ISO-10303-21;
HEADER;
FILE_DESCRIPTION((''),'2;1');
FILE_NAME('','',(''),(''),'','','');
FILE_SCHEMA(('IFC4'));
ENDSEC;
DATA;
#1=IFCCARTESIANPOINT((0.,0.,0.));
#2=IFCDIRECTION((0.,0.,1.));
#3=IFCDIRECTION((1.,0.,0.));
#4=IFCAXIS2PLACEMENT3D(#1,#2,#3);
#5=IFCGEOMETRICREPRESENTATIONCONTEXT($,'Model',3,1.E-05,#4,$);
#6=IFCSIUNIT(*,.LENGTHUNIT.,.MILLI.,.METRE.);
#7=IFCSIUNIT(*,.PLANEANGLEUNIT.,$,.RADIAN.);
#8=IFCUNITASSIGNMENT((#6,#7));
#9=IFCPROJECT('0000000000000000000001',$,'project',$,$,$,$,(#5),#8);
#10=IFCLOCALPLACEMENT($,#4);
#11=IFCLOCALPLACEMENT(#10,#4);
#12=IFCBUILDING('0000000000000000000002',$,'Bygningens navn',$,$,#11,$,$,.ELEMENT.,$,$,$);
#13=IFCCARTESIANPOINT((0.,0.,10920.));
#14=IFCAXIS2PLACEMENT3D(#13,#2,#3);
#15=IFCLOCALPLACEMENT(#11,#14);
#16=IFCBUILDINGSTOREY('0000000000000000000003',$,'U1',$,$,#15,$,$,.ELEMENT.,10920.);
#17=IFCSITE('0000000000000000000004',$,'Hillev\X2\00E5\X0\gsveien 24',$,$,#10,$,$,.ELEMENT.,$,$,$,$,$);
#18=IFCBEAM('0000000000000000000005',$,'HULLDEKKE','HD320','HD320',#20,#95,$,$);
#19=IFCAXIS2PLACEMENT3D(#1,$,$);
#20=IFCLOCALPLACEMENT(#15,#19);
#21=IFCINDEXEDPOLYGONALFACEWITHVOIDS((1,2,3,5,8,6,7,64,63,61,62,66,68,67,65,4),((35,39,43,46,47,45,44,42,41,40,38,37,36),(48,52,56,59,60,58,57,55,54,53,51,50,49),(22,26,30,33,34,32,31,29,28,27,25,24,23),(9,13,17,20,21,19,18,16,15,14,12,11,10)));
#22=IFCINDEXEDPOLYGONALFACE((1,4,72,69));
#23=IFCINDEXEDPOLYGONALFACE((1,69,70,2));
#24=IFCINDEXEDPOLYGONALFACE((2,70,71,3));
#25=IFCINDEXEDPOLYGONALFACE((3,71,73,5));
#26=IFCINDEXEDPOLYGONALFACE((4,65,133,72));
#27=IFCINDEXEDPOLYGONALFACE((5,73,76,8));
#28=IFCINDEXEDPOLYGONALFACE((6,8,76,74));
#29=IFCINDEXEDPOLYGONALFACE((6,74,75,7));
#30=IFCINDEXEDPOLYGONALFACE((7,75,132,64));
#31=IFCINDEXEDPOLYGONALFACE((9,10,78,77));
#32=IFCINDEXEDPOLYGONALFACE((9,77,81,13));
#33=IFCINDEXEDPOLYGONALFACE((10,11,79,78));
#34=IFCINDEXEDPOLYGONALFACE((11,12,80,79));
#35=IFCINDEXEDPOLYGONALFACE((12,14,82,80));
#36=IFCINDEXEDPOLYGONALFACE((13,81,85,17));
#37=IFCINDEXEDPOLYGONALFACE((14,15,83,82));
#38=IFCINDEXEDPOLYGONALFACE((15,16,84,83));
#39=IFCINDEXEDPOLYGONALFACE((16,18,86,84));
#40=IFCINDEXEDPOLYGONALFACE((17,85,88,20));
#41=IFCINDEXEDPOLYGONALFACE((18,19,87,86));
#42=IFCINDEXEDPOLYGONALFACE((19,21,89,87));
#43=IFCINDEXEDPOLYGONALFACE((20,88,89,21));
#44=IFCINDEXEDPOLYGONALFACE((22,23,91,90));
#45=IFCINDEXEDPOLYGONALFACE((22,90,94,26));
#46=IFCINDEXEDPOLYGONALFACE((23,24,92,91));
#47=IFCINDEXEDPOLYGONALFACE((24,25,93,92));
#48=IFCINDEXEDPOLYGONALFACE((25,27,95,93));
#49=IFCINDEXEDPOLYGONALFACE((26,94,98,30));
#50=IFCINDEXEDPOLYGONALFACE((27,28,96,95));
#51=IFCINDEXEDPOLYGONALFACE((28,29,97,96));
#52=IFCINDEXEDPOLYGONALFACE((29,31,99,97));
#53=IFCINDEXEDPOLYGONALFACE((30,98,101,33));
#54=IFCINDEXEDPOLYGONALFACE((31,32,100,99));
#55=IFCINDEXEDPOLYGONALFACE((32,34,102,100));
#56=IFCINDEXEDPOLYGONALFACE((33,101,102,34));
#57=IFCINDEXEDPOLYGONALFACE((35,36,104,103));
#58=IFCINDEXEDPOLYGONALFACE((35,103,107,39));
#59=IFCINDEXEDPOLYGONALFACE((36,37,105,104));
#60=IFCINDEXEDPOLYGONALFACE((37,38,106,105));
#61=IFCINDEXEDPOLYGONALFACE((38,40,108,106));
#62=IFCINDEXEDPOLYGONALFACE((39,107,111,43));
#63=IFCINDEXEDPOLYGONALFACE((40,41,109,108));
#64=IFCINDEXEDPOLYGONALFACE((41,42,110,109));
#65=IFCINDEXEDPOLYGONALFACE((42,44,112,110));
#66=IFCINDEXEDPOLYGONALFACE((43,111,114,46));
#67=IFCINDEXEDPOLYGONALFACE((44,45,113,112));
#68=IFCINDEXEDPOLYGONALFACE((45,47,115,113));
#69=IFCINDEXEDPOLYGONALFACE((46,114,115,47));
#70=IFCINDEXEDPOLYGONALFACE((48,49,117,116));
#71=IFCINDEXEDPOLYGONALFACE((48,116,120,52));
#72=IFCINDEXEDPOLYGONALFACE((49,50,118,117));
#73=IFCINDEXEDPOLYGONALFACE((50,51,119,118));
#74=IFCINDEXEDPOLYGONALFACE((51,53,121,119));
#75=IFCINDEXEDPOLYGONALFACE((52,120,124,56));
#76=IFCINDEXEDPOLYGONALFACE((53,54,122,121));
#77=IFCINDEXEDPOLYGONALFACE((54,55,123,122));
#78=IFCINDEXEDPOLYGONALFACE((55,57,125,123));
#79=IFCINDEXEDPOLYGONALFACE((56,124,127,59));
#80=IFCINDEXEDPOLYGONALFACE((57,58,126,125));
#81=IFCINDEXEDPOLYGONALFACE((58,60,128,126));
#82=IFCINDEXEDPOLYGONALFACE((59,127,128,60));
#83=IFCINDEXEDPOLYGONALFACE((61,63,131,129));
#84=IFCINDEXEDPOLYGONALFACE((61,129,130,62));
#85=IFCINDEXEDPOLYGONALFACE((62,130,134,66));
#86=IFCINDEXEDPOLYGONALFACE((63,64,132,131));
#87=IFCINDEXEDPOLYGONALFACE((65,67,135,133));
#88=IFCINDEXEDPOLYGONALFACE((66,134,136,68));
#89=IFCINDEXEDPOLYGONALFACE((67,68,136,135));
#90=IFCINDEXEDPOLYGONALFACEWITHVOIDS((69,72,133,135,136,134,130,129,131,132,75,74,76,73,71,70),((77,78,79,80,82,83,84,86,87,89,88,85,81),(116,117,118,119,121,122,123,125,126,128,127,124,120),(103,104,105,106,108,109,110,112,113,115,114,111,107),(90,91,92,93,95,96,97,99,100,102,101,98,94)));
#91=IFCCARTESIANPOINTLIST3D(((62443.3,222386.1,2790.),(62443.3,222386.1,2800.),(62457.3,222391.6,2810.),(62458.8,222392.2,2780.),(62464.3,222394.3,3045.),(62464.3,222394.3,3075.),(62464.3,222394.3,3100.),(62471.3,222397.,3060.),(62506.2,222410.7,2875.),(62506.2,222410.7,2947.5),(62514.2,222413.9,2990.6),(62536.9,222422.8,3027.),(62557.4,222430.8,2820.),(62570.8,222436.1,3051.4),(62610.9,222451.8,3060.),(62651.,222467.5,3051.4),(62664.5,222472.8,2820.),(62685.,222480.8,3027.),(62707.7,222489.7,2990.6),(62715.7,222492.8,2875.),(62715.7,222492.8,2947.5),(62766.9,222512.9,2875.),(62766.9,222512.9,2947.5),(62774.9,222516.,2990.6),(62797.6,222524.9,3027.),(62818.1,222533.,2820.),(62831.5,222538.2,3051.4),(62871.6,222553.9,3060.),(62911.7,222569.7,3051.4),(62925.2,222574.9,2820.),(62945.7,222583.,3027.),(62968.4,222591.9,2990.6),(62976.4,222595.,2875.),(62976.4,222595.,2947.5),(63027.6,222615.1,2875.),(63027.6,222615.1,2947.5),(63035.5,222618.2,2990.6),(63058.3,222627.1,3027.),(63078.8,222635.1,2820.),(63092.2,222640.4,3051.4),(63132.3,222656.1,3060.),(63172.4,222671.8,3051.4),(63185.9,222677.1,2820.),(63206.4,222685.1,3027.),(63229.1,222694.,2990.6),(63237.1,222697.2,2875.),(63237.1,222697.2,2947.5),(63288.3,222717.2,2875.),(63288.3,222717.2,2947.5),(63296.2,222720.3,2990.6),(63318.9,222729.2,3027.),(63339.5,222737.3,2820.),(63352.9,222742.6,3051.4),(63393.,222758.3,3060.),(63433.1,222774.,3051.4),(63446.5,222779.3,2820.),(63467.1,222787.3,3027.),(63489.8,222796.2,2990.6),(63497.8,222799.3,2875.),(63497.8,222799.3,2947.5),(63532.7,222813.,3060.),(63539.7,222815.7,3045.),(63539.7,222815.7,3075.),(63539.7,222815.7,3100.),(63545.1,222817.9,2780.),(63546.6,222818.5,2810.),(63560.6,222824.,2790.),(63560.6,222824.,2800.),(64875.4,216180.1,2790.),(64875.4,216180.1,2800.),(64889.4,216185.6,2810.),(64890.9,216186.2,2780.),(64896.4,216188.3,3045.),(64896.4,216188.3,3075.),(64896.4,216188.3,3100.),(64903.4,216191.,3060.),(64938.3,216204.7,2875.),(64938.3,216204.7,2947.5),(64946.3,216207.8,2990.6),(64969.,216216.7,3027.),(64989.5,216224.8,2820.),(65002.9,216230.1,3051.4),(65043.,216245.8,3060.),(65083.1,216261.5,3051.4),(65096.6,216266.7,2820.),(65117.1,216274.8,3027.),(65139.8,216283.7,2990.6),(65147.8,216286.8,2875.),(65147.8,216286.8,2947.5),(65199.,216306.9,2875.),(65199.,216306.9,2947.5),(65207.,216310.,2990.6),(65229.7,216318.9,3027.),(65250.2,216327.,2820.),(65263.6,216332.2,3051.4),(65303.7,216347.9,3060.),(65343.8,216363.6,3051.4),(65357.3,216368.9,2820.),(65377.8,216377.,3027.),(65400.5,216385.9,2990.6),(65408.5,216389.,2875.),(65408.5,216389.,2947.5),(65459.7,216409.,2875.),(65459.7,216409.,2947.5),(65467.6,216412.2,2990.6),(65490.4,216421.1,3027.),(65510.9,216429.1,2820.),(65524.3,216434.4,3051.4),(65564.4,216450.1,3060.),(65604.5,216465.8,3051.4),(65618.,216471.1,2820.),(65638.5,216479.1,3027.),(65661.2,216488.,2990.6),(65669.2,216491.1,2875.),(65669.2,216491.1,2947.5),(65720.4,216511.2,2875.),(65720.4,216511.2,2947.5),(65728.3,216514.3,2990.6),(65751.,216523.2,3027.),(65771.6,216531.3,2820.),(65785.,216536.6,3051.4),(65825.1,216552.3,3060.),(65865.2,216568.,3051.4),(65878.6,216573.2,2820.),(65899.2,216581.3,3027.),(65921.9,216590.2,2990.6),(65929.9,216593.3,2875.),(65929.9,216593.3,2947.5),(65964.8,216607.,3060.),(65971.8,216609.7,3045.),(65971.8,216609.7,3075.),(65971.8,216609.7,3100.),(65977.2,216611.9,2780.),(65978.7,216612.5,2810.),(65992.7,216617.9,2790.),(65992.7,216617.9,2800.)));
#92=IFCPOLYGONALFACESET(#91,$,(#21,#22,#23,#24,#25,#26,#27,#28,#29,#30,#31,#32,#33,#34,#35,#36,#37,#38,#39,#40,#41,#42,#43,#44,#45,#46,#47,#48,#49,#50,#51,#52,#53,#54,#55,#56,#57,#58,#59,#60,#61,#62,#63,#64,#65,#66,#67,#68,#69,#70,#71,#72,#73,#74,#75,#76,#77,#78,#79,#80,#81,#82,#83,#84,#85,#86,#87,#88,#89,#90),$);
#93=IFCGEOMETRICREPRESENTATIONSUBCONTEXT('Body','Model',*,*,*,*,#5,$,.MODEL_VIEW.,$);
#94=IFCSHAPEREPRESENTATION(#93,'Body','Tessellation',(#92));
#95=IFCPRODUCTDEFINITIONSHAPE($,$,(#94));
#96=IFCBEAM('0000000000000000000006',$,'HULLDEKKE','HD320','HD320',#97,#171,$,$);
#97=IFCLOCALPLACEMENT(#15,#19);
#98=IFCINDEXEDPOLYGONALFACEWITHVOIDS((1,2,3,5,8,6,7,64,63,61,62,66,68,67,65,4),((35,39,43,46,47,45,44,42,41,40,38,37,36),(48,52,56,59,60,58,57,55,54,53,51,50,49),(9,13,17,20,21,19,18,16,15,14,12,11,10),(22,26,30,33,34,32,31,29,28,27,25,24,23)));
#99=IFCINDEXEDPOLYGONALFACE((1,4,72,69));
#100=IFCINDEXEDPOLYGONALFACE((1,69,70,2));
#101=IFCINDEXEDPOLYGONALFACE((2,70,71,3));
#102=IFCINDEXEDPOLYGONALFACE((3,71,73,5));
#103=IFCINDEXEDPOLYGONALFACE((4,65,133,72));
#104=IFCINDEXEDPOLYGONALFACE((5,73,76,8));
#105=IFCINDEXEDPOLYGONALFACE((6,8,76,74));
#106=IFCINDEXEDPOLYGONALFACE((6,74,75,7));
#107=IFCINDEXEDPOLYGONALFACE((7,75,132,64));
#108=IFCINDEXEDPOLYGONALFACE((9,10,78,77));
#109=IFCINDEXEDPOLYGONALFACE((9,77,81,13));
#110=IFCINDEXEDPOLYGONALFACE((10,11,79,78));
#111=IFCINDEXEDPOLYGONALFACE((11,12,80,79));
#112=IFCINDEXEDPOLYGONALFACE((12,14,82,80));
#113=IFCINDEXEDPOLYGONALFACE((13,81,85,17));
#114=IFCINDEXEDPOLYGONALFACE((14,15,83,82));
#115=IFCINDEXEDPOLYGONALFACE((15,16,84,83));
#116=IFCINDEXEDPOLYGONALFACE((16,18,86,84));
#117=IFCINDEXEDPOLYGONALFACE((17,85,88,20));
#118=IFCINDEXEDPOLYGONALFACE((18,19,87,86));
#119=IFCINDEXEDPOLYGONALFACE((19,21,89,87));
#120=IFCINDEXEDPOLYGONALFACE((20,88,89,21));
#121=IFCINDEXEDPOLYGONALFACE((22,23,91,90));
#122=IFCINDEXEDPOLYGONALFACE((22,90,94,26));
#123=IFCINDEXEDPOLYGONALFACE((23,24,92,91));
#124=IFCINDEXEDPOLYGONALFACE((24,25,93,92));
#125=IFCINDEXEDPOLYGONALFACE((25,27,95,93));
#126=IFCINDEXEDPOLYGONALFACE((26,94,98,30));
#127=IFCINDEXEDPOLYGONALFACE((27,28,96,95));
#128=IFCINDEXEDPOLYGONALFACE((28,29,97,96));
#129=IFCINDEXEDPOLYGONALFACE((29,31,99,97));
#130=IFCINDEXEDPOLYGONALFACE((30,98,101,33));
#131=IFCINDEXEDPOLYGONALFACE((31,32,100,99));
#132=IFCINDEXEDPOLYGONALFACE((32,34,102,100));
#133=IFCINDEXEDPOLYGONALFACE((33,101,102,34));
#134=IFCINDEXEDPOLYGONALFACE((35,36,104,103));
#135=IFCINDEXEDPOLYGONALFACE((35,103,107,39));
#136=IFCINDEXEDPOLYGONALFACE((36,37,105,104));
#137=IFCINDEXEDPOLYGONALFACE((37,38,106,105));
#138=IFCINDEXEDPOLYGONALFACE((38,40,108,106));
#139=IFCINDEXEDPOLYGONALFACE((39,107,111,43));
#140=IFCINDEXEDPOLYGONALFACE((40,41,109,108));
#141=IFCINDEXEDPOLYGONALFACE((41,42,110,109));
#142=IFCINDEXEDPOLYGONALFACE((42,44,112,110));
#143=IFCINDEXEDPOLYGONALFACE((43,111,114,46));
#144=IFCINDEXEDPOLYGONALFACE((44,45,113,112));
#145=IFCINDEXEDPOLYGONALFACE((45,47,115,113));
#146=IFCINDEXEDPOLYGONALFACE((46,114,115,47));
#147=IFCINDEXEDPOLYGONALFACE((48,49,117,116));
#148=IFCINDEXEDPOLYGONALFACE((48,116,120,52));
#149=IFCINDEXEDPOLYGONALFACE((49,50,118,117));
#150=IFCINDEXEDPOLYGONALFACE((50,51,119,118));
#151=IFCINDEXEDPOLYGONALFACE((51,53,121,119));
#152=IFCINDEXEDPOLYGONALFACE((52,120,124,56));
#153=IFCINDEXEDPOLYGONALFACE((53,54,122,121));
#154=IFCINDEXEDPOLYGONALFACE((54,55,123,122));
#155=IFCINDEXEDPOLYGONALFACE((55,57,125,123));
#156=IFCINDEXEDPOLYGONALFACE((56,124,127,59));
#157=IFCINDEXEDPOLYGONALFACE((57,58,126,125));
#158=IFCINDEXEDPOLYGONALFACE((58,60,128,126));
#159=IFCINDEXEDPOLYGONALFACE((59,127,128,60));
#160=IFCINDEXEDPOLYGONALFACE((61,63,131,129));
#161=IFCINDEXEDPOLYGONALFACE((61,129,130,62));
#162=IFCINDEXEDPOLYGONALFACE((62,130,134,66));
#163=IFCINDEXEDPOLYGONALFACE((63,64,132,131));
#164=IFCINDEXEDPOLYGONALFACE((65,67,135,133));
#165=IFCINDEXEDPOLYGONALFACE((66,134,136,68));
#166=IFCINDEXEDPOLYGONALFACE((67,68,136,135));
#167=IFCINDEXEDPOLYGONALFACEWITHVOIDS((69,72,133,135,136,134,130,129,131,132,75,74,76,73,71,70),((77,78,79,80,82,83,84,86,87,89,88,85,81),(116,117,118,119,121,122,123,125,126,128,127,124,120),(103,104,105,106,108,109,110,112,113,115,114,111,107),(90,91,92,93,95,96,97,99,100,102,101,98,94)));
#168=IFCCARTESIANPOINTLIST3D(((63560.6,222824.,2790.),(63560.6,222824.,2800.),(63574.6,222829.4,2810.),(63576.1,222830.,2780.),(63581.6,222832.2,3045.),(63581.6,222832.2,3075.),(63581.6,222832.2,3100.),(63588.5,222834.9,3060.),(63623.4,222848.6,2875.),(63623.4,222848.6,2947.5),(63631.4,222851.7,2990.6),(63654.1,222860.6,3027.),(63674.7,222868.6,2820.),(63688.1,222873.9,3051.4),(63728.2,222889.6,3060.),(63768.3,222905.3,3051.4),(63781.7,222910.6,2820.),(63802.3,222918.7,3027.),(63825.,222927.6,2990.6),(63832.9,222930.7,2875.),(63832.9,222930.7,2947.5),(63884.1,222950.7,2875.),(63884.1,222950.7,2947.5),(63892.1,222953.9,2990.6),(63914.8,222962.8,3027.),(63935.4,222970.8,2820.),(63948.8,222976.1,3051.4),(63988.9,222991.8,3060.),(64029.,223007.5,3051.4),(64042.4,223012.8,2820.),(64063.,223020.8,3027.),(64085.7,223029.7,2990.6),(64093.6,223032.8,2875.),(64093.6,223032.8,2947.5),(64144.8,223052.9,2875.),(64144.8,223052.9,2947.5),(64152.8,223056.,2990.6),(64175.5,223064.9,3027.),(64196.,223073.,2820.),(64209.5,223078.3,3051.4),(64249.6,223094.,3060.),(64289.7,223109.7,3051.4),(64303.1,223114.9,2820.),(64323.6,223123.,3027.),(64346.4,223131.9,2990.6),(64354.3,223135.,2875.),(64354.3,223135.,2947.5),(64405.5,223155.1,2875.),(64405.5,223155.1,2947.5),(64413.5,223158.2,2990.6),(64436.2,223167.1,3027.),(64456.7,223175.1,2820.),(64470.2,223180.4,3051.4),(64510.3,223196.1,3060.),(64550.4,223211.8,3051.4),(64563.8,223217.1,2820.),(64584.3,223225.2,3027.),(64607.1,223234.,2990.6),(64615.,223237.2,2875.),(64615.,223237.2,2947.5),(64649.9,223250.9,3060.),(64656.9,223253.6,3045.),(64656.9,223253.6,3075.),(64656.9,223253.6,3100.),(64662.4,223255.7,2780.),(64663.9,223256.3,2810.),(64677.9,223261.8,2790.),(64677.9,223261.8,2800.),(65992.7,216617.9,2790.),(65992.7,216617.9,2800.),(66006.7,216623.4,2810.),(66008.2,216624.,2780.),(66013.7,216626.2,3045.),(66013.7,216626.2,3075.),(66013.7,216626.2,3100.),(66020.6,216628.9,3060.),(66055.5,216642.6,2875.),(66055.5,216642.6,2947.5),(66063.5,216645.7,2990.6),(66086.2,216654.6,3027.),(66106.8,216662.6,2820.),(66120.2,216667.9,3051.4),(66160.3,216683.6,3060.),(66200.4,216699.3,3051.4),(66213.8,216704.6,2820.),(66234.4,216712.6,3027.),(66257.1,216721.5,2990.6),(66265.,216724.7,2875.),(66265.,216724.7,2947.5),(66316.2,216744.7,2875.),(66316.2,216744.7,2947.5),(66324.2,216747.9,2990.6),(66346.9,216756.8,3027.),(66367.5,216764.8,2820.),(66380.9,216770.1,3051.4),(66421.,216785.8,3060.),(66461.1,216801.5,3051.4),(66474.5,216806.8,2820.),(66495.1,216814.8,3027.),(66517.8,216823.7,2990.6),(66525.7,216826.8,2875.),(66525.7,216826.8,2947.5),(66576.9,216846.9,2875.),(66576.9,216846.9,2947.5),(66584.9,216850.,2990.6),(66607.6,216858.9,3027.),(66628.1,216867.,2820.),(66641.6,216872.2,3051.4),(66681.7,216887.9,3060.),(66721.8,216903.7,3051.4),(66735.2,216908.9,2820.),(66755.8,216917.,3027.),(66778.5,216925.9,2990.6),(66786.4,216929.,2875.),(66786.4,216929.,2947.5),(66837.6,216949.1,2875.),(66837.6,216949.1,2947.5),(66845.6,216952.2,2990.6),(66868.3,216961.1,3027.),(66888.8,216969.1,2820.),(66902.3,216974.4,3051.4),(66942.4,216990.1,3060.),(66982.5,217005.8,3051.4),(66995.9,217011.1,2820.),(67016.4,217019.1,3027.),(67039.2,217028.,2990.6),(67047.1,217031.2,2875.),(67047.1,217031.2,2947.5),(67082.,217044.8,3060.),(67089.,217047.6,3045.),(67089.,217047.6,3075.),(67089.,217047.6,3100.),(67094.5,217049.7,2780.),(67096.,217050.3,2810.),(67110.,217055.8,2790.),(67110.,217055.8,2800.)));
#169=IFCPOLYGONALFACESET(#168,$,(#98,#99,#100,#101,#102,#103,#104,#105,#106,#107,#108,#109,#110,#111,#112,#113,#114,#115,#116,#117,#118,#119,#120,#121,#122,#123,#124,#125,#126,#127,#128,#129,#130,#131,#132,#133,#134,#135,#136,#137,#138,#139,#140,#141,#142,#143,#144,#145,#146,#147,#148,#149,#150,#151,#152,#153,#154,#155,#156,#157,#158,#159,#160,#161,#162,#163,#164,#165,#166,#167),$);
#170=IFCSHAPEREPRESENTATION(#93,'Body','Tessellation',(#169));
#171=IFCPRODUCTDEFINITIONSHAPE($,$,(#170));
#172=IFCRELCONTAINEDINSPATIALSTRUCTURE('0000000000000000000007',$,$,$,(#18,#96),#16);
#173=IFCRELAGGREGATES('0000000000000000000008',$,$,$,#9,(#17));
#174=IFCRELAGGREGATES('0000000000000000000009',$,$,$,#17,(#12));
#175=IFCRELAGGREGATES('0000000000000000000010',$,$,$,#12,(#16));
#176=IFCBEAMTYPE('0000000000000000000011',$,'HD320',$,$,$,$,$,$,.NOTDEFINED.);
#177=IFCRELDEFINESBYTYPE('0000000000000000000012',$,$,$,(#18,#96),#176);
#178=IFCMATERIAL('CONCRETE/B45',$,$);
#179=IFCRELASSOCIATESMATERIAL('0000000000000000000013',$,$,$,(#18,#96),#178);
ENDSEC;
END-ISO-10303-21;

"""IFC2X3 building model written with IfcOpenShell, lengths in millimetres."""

from ifc_helpers import new_model, si_unit, frame, origin_with_axes, place, context, subcontext, project, spatial, polyline, outline, extrude, material, type_object, element, save


model = new_model("IFC2X3")

# Units and contexts
model_context = context("Model", 3, precision=1e-05, world=origin_with_axes())
body_context = subcontext(model_context, "Body", "Model", "MODEL_VIEW")
ifc_project = project(units=[si_unit("LENGTHUNIT", "METRE", prefix="MILLI"), si_unit("PLANEANGLEUNIT", "RADIAN")], contexts=[model_context])

# Site, building, storey
site_placement = place(None, origin_with_axes())
site = spatial("IfcSite", under=ifc_project, at=site_placement, Name="Hillevågsveien 24", CompositionType="ELEMENT")
building_placement = place(site_placement, origin_with_axes())
building = spatial("IfcBuilding", under=site, at=building_placement, Name="Bygningens navn", CompositionType="ELEMENT")
storey_placement = place(building_placement, frame((0.0, 0.0, 10920.0), z_axis=(0.0, 0.0, 1.0), x_axis=(1.0, 0.0, 0.0)))
storey = spatial("IfcBuildingStorey", under=building, at=storey_placement, Name="U1", CompositionType="ELEMENT", Elevation=10920.0)

# Beams
ifc_material_1 = material(Name="CONCRETE/B45")
beam_type_1 = type_object("IfcBeamType", Name="HD320", PredefinedType="NOTDEFINED")
beam_1_placement = place(storey_placement, frame((65434.1, 216399.0, 2940.0), z_axis=(0.0, 0.0, 1.0), x_axis=(-0.364876, 0.931056, 0.0)))
element("IfcBeam", 1, at=beam_1_placement, inside=storey, type_object=beam_type_1, material=ifc_material_1, Name="HULLDEKKE", Description="HD320", ObjectType="HD320", context=body_context, shape_type="SweptSolid", body=[
    extrude(outline(polyline([(577.5, 105.0), (585.0, -130.0), (600.0, -140.0), (600.0, -150.0), (583.4, -160.0), (-583.4, -160.0), (-600.0, -150.0), (-600.0, -140.0), (-585.0, -130.0), (-577.5, 105.0), (-570.0, 120.0), (-577.5, 135.0), (-577.5, 160.0), (577.5, 160.0), (577.5, 135.0), (570.0, 120.0), (577.5, 105.0)]), holes=[polyline([(477.5, -120.0), (532.5, -65.0), (532.5, 7.5), (523.9, 50.6), (499.5, 87.0), (463.1, 111.4), (420.0, 120.0), (376.9, 111.4), (340.5, 87.0), (316.1, 50.6), (307.5, 7.5), (307.5, -65.0), (362.5, -120.0), (477.5, -120.0)]), polyline([(197.5, -120.0), (252.5, -65.0), (252.5, 7.5), (243.9, 50.6), (219.5, 87.0), (183.1, 111.4), (140.0, 120.0), (96.9, 111.4), (60.5, 87.0), (36.1, 50.6), (27.5, 7.5), (27.5, -65.0), (82.5, -120.0), (197.5, -120.0)]), polyline([(-82.5, -120.0), (-27.5, -65.0), (-27.5, 7.5), (-36.1, 50.6), (-60.5, 87.0), (-96.9, 111.4), (-140.0, 120.0), (-183.1, 111.4), (-219.5, 87.0), (-243.9, 50.6), (-252.5, 7.5), (-252.5, -65.0), (-197.5, -120.0), (-82.5, -120.0)]), polyline([(-362.5, -120.0), (-307.5, -65.0), (-307.5, 7.5), (-316.1, 50.6), (-340.5, 87.0), (-376.9, 111.4), (-420.0, 120.0), (-463.1, 111.4), (-499.5, 87.0), (-523.9, 50.6), (-532.5, 7.5), (-532.5, -65.0), (-477.5, -120.0), (-362.5, -120.0)])]), frame((6665.6, 0.0, 0.0), z_axis=(-1.0, 0.0, 0.0), x_axis=(0.0, -1.0, 0.0)), (0.0, 0.0, 1.0), 6665.6),
])
beam_2_placement = place(storey_placement, frame((66551.3, 216836.9, 2940.0), z_axis=(0.0, 0.0, 1.0), x_axis=(-0.364876, 0.931056, 0.0)))
element("IfcBeam", 2, at=beam_2_placement, inside=storey, type_object=beam_type_1, material=ifc_material_1, Name="HULLDEKKE", Description="HD320", ObjectType="HD320", context=body_context, shape_type="SweptSolid", body=[
    extrude(outline(polyline([(577.5, 105.0), (585.0, -130.0), (600.0, -140.0), (600.0, -150.0), (583.4, -160.0), (-583.4, -160.0), (-600.0, -150.0), (-600.0, -140.0), (-585.0, -130.0), (-577.5, 105.0), (-570.0, 120.0), (-577.5, 135.0), (-577.5, 160.0), (577.5, 160.0), (577.5, 135.0), (570.0, 120.0), (577.5, 105.0)]), holes=[polyline([(477.5, -120.0), (532.5, -65.0), (532.5, 7.5), (523.9, 50.6), (499.5, 87.0), (463.1, 111.4), (420.0, 120.0), (376.9, 111.4), (340.5, 87.0), (316.1, 50.6), (307.5, 7.5), (307.5, -65.0), (362.5, -120.0), (477.5, -120.0)]), polyline([(197.5, -120.0), (252.5, -65.0), (252.5, 7.5), (243.9, 50.6), (219.5, 87.0), (183.1, 111.4), (140.0, 120.0), (96.9, 111.4), (60.5, 87.0), (36.1, 50.6), (27.5, 7.5), (27.5, -65.0), (82.5, -120.0), (197.5, -120.0)]), polyline([(-82.5, -120.0), (-27.5, -65.0), (-27.5, 7.5), (-36.1, 50.6), (-60.5, 87.0), (-96.9, 111.4), (-140.0, 120.0), (-183.1, 111.4), (-219.5, 87.0), (-243.9, 50.6), (-252.5, 7.5), (-252.5, -65.0), (-197.5, -120.0), (-82.5, -120.0)]), polyline([(-362.5, -120.0), (-307.5, -65.0), (-307.5, 7.5), (-316.1, 50.6), (-340.5, 87.0), (-376.9, 111.4), (-420.0, 120.0), (-463.1, 111.4), (-499.5, 87.0), (-523.9, 50.6), (-532.5, 7.5), (-532.5, -65.0), (-477.5, -120.0), (-362.5, -120.0)])]), frame((6665.6, 0.0, 0.0), z_axis=(-1.0, 0.0, 0.0), x_axis=(0.0, -1.0, 0.0)), (0.0, 0.0, 1.0), 6665.6),
])

save(model, "model.ifc")
